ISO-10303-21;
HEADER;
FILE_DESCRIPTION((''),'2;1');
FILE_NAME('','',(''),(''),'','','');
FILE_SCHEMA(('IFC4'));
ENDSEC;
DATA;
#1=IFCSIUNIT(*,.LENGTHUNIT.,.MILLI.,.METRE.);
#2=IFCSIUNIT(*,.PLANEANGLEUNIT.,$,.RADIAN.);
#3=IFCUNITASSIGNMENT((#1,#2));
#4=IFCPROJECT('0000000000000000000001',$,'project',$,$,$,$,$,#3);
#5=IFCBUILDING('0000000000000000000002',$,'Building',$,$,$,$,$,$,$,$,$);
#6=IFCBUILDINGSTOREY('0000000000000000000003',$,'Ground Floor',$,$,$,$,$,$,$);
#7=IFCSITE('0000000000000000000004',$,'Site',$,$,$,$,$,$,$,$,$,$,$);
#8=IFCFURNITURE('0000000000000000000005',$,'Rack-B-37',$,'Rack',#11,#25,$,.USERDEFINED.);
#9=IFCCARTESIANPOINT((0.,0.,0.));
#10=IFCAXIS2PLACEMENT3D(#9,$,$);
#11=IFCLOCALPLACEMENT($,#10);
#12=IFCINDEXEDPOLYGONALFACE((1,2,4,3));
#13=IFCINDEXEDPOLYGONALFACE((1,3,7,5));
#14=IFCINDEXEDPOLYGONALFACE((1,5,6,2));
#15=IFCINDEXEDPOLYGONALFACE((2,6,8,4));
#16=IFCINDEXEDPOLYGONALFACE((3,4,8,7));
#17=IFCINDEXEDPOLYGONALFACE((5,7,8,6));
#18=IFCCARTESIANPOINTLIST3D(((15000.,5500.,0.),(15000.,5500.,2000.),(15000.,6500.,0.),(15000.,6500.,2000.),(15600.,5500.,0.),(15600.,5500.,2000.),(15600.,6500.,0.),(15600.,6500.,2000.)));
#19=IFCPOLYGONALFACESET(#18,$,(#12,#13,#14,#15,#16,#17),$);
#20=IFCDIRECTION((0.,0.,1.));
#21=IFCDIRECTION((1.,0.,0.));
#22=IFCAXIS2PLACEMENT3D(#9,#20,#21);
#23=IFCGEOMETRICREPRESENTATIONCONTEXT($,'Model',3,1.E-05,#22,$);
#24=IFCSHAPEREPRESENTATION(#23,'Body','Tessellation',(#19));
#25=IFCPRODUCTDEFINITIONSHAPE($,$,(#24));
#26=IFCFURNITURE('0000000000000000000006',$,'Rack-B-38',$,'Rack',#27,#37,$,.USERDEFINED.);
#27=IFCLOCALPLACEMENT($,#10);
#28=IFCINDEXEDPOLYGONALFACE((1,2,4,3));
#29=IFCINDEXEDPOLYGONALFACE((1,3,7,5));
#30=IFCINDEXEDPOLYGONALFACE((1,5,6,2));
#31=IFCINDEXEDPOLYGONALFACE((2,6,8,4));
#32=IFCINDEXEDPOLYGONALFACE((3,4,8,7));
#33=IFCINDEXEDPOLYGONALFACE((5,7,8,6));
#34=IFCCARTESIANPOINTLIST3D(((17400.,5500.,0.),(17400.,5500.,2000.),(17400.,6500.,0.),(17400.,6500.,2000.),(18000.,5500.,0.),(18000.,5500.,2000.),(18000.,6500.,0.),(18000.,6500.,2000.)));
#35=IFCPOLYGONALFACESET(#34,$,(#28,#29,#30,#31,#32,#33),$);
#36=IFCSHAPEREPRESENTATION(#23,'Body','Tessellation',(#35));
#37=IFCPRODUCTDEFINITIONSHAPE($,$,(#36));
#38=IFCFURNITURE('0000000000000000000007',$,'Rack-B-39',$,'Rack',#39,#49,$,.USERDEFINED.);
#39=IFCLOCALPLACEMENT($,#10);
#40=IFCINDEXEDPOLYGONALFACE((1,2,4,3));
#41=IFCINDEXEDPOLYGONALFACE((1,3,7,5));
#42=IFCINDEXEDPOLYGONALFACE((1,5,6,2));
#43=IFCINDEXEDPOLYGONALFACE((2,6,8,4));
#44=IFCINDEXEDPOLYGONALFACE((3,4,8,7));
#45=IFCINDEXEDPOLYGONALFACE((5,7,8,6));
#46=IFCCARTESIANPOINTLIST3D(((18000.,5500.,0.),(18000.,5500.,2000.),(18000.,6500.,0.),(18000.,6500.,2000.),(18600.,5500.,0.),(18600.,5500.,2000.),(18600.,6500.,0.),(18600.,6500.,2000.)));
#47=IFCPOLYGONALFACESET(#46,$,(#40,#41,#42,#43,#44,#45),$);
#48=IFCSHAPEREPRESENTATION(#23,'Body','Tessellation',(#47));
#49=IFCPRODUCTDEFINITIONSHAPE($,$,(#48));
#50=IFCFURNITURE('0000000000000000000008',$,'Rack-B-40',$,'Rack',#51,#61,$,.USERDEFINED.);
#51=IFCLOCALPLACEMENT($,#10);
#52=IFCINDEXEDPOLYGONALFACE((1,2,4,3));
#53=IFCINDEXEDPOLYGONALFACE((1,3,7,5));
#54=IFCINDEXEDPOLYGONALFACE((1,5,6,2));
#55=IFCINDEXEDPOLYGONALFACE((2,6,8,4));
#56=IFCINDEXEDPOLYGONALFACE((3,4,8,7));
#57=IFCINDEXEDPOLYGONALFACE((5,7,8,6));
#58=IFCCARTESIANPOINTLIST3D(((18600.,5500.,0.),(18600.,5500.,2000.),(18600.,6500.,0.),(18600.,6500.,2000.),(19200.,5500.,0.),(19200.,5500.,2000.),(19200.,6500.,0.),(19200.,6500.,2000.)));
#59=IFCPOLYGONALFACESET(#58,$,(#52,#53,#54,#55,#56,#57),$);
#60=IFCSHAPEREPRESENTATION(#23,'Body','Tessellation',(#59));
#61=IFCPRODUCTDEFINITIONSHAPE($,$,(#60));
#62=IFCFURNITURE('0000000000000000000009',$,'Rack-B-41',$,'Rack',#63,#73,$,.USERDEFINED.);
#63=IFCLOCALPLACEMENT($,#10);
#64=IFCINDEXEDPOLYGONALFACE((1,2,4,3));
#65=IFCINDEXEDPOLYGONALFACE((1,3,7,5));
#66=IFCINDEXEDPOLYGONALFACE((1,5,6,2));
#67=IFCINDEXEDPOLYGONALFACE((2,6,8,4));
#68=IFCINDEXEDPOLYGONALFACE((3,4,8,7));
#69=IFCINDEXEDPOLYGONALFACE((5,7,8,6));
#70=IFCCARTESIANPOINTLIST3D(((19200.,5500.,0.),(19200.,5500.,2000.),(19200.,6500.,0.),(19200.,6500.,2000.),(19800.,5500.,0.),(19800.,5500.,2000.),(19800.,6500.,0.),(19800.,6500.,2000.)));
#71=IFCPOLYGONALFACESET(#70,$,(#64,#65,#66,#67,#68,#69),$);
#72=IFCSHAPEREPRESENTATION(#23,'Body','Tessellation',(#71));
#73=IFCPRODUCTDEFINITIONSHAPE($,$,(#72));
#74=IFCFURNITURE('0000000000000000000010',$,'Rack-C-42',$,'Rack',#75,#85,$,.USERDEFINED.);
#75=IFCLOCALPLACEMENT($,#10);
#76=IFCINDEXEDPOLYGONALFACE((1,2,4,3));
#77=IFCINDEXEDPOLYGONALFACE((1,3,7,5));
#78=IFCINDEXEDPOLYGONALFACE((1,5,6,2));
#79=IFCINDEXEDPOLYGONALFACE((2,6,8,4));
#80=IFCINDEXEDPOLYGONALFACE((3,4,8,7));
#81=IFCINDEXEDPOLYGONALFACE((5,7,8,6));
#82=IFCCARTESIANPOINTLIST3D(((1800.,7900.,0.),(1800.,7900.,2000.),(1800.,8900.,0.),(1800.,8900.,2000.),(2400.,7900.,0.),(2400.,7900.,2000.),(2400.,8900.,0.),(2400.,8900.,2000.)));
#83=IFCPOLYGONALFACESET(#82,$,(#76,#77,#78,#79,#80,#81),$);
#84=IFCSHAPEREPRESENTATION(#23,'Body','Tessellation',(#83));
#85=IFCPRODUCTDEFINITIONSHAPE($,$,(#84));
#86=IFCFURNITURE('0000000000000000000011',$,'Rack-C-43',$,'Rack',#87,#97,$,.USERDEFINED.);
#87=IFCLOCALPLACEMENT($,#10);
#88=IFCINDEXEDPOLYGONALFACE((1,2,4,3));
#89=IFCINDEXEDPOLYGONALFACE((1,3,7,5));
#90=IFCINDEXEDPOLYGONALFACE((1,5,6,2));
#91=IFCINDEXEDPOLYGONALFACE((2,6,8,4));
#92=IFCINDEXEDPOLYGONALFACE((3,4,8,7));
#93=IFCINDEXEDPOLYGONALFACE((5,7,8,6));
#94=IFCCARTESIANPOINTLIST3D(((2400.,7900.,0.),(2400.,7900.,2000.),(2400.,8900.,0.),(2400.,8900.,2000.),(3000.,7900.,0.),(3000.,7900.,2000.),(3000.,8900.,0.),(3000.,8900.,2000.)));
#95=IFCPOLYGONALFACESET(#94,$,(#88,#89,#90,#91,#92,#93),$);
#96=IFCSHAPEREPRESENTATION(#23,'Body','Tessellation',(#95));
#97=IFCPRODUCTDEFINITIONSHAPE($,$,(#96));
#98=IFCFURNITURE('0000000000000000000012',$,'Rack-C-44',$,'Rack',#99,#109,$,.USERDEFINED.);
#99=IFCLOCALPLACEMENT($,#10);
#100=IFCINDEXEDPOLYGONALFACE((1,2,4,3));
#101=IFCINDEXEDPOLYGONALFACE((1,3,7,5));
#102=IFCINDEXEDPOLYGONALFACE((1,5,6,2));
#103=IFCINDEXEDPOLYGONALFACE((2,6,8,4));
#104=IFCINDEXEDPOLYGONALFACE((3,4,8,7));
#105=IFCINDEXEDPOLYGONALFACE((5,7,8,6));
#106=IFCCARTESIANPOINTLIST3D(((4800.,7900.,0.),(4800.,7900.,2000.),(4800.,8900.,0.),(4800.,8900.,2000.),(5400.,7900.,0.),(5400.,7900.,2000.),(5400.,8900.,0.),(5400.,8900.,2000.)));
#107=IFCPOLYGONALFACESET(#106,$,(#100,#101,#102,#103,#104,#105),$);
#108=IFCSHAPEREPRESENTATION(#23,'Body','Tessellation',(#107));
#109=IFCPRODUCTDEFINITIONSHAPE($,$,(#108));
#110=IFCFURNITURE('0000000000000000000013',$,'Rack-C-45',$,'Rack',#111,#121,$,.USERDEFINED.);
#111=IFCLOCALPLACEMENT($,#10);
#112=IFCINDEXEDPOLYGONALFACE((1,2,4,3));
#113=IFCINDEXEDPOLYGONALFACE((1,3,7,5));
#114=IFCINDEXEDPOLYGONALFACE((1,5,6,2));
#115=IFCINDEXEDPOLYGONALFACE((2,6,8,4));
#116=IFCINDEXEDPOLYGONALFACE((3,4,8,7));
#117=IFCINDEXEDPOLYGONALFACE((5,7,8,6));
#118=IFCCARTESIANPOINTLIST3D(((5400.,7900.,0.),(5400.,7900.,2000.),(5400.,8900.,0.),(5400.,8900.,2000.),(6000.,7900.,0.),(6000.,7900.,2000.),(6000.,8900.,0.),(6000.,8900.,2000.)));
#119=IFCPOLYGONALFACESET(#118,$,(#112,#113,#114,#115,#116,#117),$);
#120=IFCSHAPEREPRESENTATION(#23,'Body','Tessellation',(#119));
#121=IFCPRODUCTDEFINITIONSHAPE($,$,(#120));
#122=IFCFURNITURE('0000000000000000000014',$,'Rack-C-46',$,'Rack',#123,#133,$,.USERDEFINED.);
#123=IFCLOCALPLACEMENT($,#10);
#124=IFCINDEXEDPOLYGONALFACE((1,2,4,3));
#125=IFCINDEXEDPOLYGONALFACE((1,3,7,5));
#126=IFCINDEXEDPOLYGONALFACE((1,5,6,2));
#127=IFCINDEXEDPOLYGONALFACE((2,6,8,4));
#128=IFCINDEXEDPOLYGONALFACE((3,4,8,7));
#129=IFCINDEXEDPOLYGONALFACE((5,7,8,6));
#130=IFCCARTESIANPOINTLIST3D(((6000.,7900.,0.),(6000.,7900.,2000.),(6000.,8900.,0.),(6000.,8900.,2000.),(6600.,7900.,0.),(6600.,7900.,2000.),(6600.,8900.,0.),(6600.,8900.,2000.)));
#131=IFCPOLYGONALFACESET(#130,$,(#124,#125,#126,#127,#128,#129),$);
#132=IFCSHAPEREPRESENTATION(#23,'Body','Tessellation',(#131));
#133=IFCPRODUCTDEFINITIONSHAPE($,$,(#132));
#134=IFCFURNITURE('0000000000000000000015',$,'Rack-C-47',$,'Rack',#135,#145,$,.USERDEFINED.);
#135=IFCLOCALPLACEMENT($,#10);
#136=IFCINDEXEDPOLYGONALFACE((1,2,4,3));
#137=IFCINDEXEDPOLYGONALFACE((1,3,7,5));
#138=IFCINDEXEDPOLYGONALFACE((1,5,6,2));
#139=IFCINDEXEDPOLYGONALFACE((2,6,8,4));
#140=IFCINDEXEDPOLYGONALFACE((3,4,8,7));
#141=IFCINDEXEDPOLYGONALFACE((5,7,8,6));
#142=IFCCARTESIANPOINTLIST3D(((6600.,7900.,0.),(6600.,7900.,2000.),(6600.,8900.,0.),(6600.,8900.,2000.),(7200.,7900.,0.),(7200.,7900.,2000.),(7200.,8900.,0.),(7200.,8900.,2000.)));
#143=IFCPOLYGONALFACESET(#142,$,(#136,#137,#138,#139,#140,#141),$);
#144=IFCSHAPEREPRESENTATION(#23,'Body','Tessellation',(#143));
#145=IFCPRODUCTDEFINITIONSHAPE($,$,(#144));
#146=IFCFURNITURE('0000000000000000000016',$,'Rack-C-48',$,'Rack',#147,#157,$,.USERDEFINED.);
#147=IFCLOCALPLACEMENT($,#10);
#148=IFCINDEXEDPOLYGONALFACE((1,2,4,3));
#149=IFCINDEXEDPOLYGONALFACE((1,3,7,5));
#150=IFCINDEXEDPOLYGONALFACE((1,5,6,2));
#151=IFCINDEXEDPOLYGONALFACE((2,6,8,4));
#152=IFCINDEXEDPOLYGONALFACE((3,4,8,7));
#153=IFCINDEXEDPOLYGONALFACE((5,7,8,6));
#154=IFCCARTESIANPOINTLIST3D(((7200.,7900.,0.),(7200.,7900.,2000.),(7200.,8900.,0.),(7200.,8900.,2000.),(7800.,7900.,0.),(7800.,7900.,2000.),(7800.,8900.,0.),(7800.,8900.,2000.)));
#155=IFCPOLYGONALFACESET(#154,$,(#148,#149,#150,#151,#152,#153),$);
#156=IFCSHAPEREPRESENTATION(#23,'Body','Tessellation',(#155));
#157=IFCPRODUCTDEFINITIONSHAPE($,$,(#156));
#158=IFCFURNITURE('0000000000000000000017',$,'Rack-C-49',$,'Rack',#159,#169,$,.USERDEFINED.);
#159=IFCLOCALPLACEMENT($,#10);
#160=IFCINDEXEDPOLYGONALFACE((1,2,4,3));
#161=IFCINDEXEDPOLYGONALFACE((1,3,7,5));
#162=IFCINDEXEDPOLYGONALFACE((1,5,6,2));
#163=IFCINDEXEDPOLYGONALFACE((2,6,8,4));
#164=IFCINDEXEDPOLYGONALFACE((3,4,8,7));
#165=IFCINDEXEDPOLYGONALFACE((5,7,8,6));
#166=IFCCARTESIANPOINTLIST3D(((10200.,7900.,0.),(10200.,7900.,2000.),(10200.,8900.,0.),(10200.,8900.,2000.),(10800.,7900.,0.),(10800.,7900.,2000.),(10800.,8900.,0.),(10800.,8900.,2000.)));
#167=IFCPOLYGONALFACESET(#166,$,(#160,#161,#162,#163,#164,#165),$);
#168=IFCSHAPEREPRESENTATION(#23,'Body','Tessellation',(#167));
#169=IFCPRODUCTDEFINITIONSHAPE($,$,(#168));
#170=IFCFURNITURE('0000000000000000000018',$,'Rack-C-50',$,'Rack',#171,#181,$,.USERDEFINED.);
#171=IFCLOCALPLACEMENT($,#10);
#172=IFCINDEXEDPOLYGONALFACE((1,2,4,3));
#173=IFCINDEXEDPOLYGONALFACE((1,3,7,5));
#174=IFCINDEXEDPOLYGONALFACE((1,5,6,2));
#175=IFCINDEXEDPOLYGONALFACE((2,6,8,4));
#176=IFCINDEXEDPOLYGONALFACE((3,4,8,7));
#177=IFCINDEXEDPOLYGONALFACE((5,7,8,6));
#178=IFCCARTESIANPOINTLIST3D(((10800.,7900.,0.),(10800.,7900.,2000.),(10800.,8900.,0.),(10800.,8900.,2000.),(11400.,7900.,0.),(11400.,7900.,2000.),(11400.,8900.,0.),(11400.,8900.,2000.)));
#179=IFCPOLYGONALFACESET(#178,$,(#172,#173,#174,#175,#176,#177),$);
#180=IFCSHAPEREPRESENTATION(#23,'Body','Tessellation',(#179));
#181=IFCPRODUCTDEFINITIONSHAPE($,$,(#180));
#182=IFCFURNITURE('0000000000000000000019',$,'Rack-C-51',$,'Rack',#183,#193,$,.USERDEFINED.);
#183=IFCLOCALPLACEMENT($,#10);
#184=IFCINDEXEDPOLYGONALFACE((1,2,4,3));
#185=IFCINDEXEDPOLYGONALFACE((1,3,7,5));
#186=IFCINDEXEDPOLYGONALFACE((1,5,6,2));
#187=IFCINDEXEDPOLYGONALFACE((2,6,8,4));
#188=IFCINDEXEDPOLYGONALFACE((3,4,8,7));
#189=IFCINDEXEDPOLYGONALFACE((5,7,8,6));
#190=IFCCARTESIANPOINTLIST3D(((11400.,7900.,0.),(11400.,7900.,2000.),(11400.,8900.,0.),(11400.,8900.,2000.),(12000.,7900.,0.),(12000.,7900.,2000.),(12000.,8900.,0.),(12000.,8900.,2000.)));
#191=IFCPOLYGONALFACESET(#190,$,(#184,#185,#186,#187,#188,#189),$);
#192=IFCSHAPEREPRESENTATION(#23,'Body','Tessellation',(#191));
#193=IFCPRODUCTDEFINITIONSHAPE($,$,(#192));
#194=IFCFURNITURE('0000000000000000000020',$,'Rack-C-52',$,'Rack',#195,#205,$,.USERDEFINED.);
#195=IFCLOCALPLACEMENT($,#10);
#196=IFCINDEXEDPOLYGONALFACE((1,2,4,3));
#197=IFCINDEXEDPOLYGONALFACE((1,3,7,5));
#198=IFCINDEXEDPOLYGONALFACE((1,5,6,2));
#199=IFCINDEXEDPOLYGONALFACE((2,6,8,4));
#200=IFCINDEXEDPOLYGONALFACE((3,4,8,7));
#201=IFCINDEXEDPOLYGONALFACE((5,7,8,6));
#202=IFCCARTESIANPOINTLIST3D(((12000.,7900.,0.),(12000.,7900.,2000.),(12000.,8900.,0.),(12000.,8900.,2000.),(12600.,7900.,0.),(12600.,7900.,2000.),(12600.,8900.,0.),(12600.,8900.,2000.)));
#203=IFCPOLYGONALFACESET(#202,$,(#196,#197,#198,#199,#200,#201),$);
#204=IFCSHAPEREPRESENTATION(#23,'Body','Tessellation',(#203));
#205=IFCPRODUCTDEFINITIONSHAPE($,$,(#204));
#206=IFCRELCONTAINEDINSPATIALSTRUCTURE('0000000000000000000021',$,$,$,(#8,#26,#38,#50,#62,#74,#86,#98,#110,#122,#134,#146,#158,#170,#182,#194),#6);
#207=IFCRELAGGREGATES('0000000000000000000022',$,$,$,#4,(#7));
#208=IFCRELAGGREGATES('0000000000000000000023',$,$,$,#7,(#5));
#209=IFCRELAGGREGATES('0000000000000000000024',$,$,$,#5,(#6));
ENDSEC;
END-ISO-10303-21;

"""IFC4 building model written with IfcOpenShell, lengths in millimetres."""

from ifc_helpers import new_model, si_unit, frame, origin_with_axes, place, context, project, spatial, rectangle, extrude, element, save


model = new_model("IFC4")

# Units and contexts
model_context = context("Model", 3, precision=1e-05, world=origin_with_axes())
ifc_project = project(units=[si_unit("LENGTHUNIT", "METRE", prefix="MILLI"), si_unit("PLANEANGLEUNIT", "RADIAN")])

# Site, building, storey
site = spatial("IfcSite", under=ifc_project, Name="Site")
building = spatial("IfcBuilding", under=site, Name="Building")
storey = spatial("IfcBuildingStorey", under=building, Name="Ground Floor")

# Furniture
furniture_1_placement = place(None, origin_with_axes())
element("IfcFurniture", 1, at=furniture_1_placement, inside=storey, Name="Rack-B-37", ObjectType="Rack", PredefinedType="USERDEFINED", context=model_context, shape_type="SweptSolid", body=[
    extrude(rectangle(XDim=600.0, YDim=1000.0), frame((15300.0, 6000.0, 0.0), z_axis=(0.0, 0.0, 1.0), x_axis=(1.0, 0.0, 0.0)), (0.0, 0.0, 1.0), 2000.0),
])
furniture_2_placement = place(None, origin_with_axes())
element("IfcFurniture", 2, at=furniture_2_placement, inside=storey, Name="Rack-B-38", ObjectType="Rack", PredefinedType="USERDEFINED", context=model_context, shape_type="SweptSolid", body=[
    extrude(rectangle(XDim=600.0, YDim=1000.0), frame((17700.0, 6000.0, 0.0), z_axis=(0.0, 0.0, 1.0), x_axis=(1.0, 0.0, 0.0)), (0.0, 0.0, 1.0), 2000.0),
])
furniture_3_placement = place(None, origin_with_axes())
element("IfcFurniture", 3, at=furniture_3_placement, inside=storey, Name="Rack-B-39", ObjectType="Rack", PredefinedType="USERDEFINED", context=model_context, shape_type="SweptSolid", body=[
    extrude(rectangle(XDim=600.0, YDim=1000.0), frame((18300.0, 6000.0, 0.0), z_axis=(0.0, 0.0, 1.0), x_axis=(1.0, 0.0, 0.0)), (0.0, 0.0, 1.0), 2000.0),
])
furniture_4_placement = place(None, origin_with_axes())
element("IfcFurniture", 4, at=furniture_4_placement, inside=storey, Name="Rack-B-40", ObjectType="Rack", PredefinedType="USERDEFINED", context=model_context, shape_type="SweptSolid", body=[
    extrude(rectangle(XDim=600.0, YDim=1000.0), frame((18900.0, 6000.0, 0.0), z_axis=(0.0, 0.0, 1.0), x_axis=(1.0, 0.0, 0.0)), (0.0, 0.0, 1.0), 2000.0),
])
furniture_5_placement = place(None, origin_with_axes())
element("IfcFurniture", 5, at=furniture_5_placement, inside=storey, Name="Rack-B-41", ObjectType="Rack", PredefinedType="USERDEFINED", context=model_context, shape_type="SweptSolid", body=[
    extrude(rectangle(XDim=600.0, YDim=1000.0), frame((19500.0, 6000.0, 0.0), z_axis=(0.0, 0.0, 1.0), x_axis=(1.0, 0.0, 0.0)), (0.0, 0.0, 1.0), 2000.0),
])
furniture_6_placement = place(None, origin_with_axes())
element("IfcFurniture", 6, at=furniture_6_placement, inside=storey, Name="Rack-C-42", ObjectType="Rack", PredefinedType="USERDEFINED", context=model_context, shape_type="SweptSolid", body=[
    extrude(rectangle(XDim=600.0, YDim=1000.0), frame((2100.0, 8400.0, 0.0), z_axis=(0.0, 0.0, 1.0), x_axis=(1.0, 0.0, 0.0)), (0.0, 0.0, 1.0), 2000.0),
])
furniture_7_placement = place(None, origin_with_axes())
element("IfcFurniture", 7, at=furniture_7_placement, inside=storey, Name="Rack-C-43", ObjectType="Rack", PredefinedType="USERDEFINED", context=model_context, shape_type="SweptSolid", body=[
    extrude(rectangle(XDim=600.0, YDim=1000.0), frame((2700.0, 8400.0, 0.0), z_axis=(0.0, 0.0, 1.0), x_axis=(1.0, 0.0, 0.0)), (0.0, 0.0, 1.0), 2000.0),
])
furniture_8_placement = place(None, origin_with_axes())
element("IfcFurniture", 8, at=furniture_8_placement, inside=storey, Name="Rack-C-44", ObjectType="Rack", PredefinedType="USERDEFINED", context=model_context, shape_type="SweptSolid", body=[
    extrude(rectangle(XDim=600.0, YDim=1000.0), frame((5100.0, 8400.0, 0.0), z_axis=(0.0, 0.0, 1.0), x_axis=(1.0, 0.0, 0.0)), (0.0, 0.0, 1.0), 2000.0),
])
furniture_9_placement = place(None, origin_with_axes())
element("IfcFurniture", 9, at=furniture_9_placement, inside=storey, Name="Rack-C-45", ObjectType="Rack", PredefinedType="USERDEFINED", context=model_context, shape_type="SweptSolid", body=[
    extrude(rectangle(XDim=600.0, YDim=1000.0), frame((5700.0, 8400.0, 0.0), z_axis=(0.0, 0.0, 1.0), x_axis=(1.0, 0.0, 0.0)), (0.0, 0.0, 1.0), 2000.0),
])
furniture_10_placement = place(None, origin_with_axes())
element("IfcFurniture", 10, at=furniture_10_placement, inside=storey, Name="Rack-C-46", ObjectType="Rack", PredefinedType="USERDEFINED", context=model_context, shape_type="SweptSolid", body=[
    extrude(rectangle(XDim=600.0, YDim=1000.0), frame((6300.0, 8400.0, 0.0), z_axis=(0.0, 0.0, 1.0), x_axis=(1.0, 0.0, 0.0)), (0.0, 0.0, 1.0), 2000.0),
])
furniture_11_placement = place(None, origin_with_axes())
element("IfcFurniture", 11, at=furniture_11_placement, inside=storey, Name="Rack-C-47", ObjectType="Rack", PredefinedType="USERDEFINED", context=model_context, shape_type="SweptSolid", body=[
    extrude(rectangle(XDim=600.0, YDim=1000.0), frame((6900.0, 8400.0, 0.0), z_axis=(0.0, 0.0, 1.0), x_axis=(1.0, 0.0, 0.0)), (0.0, 0.0, 1.0), 2000.0),
])
furniture_12_placement = place(None, origin_with_axes())
element("IfcFurniture", 12, at=furniture_12_placement, inside=storey, Name="Rack-C-48", ObjectType="Rack", PredefinedType="USERDEFINED", context=model_context, shape_type="SweptSolid", body=[
    extrude(rectangle(XDim=600.0, YDim=1000.0), frame((7500.0, 8400.0, 0.0), z_axis=(0.0, 0.0, 1.0), x_axis=(1.0, 0.0, 0.0)), (0.0, 0.0, 1.0), 2000.0),
])
furniture_13_placement = place(None, origin_with_axes())
element("IfcFurniture", 13, at=furniture_13_placement, inside=storey, Name="Rack-C-49", ObjectType="Rack", PredefinedType="USERDEFINED", context=model_context, shape_type="SweptSolid", body=[
    extrude(rectangle(XDim=600.0, YDim=1000.0), frame((10500.0, 8400.0, 0.0), z_axis=(0.0, 0.0, 1.0), x_axis=(1.0, 0.0, 0.0)), (0.0, 0.0, 1.0), 2000.0),
])
furniture_14_placement = place(None, origin_with_axes())
element("IfcFurniture", 14, at=furniture_14_placement, inside=storey, Name="Rack-C-50", ObjectType="Rack", PredefinedType="USERDEFINED", context=model_context, shape_type="SweptSolid", body=[
    extrude(rectangle(XDim=600.0, YDim=1000.0), frame((11100.0, 8400.0, 0.0), z_axis=(0.0, 0.0, 1.0), x_axis=(1.0, 0.0, 0.0)), (0.0, 0.0, 1.0), 2000.0),
])
furniture_15_placement = place(None, origin_with_axes())
element("IfcFurniture", 15, at=furniture_15_placement, inside=storey, Name="Rack-C-51", ObjectType="Rack", PredefinedType="USERDEFINED", context=model_context, shape_type="SweptSolid", body=[
    extrude(rectangle(XDim=600.0, YDim=1000.0), frame((11700.0, 8400.0, 0.0), z_axis=(0.0, 0.0, 1.0), x_axis=(1.0, 0.0, 0.0)), (0.0, 0.0, 1.0), 2000.0),
])
furniture_16_placement = place(None, origin_with_axes())
element("IfcFurniture", 16, at=furniture_16_placement, inside=storey, Name="Rack-C-52", ObjectType="Rack", PredefinedType="USERDEFINED", context=model_context, shape_type="SweptSolid", body=[
    extrude(rectangle(XDim=600.0, YDim=1000.0), frame((12300.0, 8400.0, 0.0), z_axis=(0.0, 0.0, 1.0), x_axis=(1.0, 0.0, 0.0)), (0.0, 0.0, 1.0), 2000.0),
])

save(model, "model.ifc")
